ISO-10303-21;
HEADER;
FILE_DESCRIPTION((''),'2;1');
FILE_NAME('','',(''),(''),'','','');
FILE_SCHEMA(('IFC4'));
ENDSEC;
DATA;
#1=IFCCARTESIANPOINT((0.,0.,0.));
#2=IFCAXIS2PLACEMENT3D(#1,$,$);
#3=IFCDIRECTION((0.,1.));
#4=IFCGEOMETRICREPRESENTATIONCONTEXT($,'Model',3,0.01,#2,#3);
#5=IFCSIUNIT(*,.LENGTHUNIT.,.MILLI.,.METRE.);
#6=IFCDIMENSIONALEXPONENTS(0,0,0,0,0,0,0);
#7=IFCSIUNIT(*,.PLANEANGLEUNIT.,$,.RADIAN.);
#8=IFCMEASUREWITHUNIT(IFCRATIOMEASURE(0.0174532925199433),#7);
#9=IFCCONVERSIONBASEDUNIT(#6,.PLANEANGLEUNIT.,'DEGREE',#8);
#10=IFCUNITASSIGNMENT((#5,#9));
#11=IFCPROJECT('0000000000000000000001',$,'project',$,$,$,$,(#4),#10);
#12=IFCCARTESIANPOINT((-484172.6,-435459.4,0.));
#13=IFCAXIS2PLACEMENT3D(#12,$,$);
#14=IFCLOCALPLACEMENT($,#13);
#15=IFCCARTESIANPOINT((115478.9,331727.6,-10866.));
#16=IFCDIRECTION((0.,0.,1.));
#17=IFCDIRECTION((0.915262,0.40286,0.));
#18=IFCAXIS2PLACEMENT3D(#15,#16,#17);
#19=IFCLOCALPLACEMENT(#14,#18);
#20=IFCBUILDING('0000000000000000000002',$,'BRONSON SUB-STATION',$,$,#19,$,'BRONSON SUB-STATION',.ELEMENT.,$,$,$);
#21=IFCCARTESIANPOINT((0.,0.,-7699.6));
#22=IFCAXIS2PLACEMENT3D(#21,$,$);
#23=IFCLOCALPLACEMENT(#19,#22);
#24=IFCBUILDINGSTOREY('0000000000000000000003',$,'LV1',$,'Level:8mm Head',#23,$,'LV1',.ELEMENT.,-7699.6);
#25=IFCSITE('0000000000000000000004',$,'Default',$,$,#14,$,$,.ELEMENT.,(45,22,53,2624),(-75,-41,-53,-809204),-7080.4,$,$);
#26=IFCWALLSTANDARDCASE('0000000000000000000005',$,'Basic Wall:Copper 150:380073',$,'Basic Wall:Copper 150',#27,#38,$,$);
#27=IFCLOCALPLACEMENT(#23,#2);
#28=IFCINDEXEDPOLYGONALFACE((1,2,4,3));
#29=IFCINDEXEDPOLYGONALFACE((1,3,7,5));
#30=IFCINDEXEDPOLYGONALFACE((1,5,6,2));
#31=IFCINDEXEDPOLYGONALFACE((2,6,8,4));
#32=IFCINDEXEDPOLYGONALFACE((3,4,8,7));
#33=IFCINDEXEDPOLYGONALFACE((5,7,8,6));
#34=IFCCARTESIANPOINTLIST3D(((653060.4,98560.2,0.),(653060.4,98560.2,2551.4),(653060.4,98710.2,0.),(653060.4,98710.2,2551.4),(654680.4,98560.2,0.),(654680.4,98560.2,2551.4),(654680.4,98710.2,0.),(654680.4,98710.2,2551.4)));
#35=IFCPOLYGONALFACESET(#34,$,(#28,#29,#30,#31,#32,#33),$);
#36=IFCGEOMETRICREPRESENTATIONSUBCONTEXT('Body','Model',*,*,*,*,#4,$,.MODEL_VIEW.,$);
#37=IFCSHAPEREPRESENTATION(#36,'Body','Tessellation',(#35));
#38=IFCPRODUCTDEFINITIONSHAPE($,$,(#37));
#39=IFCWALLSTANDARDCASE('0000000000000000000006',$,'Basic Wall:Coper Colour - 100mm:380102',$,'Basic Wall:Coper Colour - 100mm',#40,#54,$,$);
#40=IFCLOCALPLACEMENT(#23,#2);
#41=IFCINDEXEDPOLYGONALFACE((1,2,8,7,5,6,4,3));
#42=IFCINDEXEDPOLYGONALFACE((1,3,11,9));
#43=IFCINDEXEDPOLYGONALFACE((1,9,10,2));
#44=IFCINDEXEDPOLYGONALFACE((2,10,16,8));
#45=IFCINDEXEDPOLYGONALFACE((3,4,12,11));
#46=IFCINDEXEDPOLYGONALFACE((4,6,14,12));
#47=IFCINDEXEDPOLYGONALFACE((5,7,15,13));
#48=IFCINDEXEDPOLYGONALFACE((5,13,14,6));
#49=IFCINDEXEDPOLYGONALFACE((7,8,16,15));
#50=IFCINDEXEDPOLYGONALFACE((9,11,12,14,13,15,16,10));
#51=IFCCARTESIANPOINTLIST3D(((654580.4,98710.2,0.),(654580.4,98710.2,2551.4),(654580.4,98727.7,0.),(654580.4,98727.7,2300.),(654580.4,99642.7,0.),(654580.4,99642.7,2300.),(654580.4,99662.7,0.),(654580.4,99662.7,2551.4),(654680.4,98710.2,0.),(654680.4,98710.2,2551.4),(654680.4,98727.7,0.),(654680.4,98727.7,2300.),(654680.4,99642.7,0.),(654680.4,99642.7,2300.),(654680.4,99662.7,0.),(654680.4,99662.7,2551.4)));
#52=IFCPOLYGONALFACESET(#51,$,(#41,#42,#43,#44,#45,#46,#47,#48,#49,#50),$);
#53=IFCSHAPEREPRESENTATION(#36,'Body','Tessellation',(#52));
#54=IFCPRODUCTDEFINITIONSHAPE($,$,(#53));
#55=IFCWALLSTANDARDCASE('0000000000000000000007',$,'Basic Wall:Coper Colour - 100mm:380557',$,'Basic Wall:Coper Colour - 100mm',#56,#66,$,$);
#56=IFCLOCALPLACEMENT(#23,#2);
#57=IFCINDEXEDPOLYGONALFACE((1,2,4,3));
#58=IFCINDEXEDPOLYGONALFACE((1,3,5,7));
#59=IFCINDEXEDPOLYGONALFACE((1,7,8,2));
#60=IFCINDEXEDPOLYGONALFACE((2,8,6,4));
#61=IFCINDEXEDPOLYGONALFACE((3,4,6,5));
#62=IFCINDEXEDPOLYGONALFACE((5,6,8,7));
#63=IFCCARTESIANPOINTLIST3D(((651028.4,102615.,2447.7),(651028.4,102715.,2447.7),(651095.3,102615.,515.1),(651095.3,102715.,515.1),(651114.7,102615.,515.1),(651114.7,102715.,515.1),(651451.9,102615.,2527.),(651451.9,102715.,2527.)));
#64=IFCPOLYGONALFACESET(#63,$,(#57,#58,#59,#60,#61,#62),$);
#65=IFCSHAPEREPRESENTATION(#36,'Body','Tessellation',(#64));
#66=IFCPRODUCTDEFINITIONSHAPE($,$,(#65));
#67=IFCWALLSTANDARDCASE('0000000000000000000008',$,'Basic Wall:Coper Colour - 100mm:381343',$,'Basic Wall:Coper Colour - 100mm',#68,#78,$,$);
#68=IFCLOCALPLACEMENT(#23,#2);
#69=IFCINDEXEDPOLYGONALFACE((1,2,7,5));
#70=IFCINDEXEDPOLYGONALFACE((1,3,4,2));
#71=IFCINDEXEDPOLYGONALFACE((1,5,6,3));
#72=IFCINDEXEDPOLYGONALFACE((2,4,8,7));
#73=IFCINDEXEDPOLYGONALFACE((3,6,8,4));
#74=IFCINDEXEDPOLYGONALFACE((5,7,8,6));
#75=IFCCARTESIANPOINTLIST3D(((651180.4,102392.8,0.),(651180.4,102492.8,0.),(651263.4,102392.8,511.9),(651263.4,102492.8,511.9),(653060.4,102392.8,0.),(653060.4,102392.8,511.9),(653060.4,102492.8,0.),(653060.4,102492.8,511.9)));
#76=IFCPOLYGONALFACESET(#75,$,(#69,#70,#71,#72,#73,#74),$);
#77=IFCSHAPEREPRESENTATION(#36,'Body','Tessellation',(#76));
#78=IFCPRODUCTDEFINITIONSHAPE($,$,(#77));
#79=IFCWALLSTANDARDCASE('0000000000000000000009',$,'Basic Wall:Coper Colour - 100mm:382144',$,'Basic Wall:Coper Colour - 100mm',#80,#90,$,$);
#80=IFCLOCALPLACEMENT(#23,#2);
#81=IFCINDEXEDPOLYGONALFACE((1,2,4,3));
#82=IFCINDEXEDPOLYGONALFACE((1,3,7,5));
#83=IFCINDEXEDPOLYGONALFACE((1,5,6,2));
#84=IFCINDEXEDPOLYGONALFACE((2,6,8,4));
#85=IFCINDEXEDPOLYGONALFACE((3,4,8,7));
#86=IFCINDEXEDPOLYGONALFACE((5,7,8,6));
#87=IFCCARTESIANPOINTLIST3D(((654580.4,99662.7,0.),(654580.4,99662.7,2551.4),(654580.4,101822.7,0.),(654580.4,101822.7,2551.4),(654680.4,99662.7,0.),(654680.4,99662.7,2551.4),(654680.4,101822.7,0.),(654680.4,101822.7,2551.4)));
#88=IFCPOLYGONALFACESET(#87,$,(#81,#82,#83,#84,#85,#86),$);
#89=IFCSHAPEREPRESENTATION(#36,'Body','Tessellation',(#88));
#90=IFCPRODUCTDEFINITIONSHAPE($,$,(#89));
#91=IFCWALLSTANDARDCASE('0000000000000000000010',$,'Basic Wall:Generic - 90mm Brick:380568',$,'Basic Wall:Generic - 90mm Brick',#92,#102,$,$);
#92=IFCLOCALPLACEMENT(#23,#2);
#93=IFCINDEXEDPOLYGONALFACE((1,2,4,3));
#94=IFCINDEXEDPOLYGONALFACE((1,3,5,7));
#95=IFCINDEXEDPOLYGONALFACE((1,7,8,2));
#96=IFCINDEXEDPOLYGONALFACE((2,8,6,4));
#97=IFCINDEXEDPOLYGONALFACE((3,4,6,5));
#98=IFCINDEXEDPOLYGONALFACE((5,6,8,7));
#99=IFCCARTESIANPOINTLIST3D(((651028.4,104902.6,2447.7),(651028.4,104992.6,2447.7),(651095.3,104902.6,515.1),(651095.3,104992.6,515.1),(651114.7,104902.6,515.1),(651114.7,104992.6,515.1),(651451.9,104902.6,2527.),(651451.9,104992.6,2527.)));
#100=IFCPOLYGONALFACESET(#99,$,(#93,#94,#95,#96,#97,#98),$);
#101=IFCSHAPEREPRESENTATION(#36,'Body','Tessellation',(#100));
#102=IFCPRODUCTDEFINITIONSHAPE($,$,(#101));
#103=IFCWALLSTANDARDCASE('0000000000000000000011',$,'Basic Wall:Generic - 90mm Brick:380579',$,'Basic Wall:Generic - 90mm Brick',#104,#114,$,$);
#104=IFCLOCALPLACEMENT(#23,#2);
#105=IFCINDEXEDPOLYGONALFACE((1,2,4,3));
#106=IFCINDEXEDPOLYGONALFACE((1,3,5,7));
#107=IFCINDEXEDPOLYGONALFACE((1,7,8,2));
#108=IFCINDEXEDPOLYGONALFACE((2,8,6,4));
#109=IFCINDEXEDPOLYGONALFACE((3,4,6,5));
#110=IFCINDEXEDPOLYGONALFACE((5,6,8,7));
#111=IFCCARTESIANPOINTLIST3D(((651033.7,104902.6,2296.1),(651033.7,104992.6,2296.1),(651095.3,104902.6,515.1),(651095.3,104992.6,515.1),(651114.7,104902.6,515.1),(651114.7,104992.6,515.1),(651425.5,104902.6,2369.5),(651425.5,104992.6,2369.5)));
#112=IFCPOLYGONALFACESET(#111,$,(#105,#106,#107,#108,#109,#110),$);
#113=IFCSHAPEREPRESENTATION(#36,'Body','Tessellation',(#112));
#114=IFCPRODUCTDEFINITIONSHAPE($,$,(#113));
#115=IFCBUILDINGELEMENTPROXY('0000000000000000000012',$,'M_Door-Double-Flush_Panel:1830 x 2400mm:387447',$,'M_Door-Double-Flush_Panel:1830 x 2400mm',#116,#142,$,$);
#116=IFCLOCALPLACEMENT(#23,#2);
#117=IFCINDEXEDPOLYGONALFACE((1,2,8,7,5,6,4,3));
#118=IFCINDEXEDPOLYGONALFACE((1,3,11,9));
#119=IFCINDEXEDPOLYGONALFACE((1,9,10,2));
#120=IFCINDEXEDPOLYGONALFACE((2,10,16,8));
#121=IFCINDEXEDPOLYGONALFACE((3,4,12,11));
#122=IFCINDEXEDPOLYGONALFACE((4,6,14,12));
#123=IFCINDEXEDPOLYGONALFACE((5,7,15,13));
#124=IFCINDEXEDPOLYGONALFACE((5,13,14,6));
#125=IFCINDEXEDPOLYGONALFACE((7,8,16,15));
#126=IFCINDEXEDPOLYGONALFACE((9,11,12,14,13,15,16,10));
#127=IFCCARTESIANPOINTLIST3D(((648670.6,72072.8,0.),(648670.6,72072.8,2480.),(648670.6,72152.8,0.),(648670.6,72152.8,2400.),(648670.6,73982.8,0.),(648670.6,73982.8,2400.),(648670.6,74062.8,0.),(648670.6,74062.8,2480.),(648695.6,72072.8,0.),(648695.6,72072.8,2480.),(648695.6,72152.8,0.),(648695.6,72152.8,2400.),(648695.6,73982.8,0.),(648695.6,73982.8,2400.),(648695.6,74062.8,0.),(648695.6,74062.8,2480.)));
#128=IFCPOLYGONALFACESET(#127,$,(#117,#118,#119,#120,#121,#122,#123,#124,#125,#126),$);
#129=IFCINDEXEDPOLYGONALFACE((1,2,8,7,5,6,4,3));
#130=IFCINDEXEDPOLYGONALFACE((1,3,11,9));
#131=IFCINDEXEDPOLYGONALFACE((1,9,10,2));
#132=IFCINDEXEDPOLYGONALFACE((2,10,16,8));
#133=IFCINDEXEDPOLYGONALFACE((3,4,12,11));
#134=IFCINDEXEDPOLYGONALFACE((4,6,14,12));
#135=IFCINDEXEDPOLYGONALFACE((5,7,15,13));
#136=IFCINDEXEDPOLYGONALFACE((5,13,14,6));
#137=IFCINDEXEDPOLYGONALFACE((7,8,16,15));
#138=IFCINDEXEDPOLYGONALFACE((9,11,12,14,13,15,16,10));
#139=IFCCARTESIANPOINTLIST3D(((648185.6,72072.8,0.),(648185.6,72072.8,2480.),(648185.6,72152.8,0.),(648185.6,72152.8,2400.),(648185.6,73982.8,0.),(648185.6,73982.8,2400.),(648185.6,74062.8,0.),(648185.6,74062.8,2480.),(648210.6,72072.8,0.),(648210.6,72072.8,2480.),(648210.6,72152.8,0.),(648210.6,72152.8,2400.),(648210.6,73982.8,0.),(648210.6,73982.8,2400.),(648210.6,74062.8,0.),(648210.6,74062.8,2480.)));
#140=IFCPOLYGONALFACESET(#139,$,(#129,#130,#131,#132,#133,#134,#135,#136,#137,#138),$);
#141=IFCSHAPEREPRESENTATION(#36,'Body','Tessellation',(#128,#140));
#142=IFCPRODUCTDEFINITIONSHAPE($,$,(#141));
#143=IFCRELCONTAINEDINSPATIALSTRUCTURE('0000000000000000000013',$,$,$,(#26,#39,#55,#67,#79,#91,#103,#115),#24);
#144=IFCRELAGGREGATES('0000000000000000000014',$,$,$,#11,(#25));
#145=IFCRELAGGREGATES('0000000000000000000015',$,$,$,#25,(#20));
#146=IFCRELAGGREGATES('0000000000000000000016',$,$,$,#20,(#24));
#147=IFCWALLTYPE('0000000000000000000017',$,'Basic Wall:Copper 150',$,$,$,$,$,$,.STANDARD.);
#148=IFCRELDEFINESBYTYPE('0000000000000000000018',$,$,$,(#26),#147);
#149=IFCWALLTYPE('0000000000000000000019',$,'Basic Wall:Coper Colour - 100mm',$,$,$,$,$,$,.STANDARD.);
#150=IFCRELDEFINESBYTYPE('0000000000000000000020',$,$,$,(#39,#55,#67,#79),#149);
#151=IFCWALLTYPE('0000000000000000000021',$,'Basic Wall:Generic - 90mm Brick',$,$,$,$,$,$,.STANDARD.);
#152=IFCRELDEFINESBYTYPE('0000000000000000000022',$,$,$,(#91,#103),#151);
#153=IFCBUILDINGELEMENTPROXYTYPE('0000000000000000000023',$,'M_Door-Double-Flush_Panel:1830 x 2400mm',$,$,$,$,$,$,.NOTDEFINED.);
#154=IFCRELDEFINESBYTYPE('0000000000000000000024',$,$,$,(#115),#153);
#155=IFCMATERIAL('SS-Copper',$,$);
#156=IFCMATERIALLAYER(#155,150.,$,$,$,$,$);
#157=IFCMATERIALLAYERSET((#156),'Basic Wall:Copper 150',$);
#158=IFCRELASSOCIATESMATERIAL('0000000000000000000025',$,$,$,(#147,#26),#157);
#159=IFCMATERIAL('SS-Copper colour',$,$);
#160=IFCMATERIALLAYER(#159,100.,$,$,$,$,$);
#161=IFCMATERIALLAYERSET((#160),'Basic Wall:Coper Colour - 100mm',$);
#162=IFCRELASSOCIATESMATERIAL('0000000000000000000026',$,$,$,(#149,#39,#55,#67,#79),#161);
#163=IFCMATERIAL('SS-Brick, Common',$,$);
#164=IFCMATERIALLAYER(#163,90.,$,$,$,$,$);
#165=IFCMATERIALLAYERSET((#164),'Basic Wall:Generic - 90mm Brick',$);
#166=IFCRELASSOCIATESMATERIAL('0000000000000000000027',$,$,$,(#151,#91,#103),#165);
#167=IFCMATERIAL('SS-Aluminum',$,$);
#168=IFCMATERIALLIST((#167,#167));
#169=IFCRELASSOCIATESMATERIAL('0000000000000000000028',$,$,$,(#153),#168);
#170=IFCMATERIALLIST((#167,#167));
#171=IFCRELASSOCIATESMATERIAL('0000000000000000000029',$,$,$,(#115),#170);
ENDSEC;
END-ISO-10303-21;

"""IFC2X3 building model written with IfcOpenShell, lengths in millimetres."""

from ifc_helpers import new_model, entity, si_unit, converted_unit, direction, frame, frame_2d, origin, place, context, subcontext, project, spatial, polyline, rectangle, outline, extrude, clip, halfspace, source, transform, mapped, material, material_list, layer, layer_set, layer_usage, type_object, type_shapes, element, save


model = new_model("IFC2X3")

# Units and contexts
model_context = context("Model", 3, precision=0.01, world=origin(), true_north=direction((0.0, 1.0)))
body_context = subcontext(model_context, "Body", "Model", "MODEL_VIEW")
ifc_project = project(units=[si_unit("LENGTHUNIT", "METRE", prefix="MILLI"), converted_unit("PLANEANGLEUNIT", "DEGREE", entity("IfcRatioMeasure", 0.0174532925199433), si_unit("PLANEANGLEUNIT", "RADIAN"), dimensions=[0, 0, 0, 0, 0, 0, 0])], contexts=[model_context])

# Site, building, storey
site_placement = place(None, frame((-484172.6, -435459.4, 0.0)))
site = spatial("IfcSite", under=ifc_project, at=site_placement, Name="Default", CompositionType="ELEMENT", RefLatitude=(45, 22, 53, 2624), RefLongitude=(-75, -41, -53, -809204), RefElevation=-7080.4)
building_placement = place(site_placement, frame((115478.9, 331727.6, -10866.0), z_axis=(0.0, 0.0, 1.0), x_axis=(0.915262, 0.40286, 0.0)))
building = spatial("IfcBuilding", under=site, at=building_placement, Name="BRONSON SUB-STATION", LongName="BRONSON SUB-STATION", CompositionType="ELEMENT")
storey_placement = place(building_placement, frame((0.0, 0.0, -7699.6)))
storey = spatial("IfcBuildingStorey", under=building, at=storey_placement, Name="LV1", ObjectType="Level:8mm Head", LongName="LV1", CompositionType="ELEMENT", Elevation=-7699.6)

# Shared definitions
ifc_material_1 = material(Name="SS-Copper")
ifc_layer_1 = layer(ifc_material_1, 150.0)
ifc_layer_set_1 = layer_set([ifc_layer_1], Name="Basic Wall:Copper 150")
wall_type_1 = type_object("IfcWallType", Name="Basic Wall:Copper 150", PredefinedType="STANDARD", material=ifc_layer_set_1)

# Wall
ifc_layer_usage_1 = layer_usage(ifc_layer_set_1, "AXIS2", "NEGATIVE", 75.0)
wall_1_placement = place(storey_placement, frame((653060.4, 98635.2, 0.0)))
element("IfcWallStandardCase", 1, at=wall_1_placement, inside=storey, type_object=wall_type_1, material=ifc_layer_usage_1, Name="Basic Wall:Copper 150:380073", ObjectType="Basic Wall:Copper 150", context=body_context, shape_type="SweptSolid", body=[
    extrude(rectangle(XDim=1620.0, YDim=150.0, at=frame_2d((810.0, 0.0), x_axis=(-1.0, 0.0))), origin(), (0.0, 0.0, 1.0), 2551.4),
])

# Wall, opening
ifc_material_2 = material(Name="SS-Copper colour")
ifc_layer_2 = layer(ifc_material_2, 100.0)
ifc_layer_set_2 = layer_set([ifc_layer_2], Name="Basic Wall:Coper Colour - 100mm")
ifc_layer_usage_2 = layer_usage(ifc_layer_set_2, "AXIS2", "NEGATIVE", 50.0)
wall_type_2 = type_object("IfcWallType", Name="Basic Wall:Coper Colour - 100mm", PredefinedType="STANDARD", material=ifc_layer_set_2)
wall_2_placement = place(storey_placement, frame((654630.4, 98710.2, 0.0), z_axis=(0.0, 0.0, 1.0), x_axis=(0.0, 1.0, 0.0)))
wall_2 = element("IfcWallStandardCase", 2, at=wall_2_placement, inside=storey, type_object=wall_type_2, material=ifc_layer_usage_2, Name="Basic Wall:Coper Colour - 100mm:380102", ObjectType="Basic Wall:Coper Colour - 100mm", context=body_context, shape_type="SweptSolid", body=[
    extrude(rectangle(XDim=952.5, YDim=100.0, at=frame_2d((476.3, 0.0), x_axis=(-1.0, 0.0))), origin(), (0.0, 0.0, 1.0), 2551.4),
])
opening_1_placement = place(wall_2_placement, origin())
element("IfcOpeningElement", 3, at=opening_1_placement, cuts=wall_2, ObjectType="Opening", context=body_context, shape_type="SweptSolid", body=[
    extrude(rectangle(XDim=2300.0, YDim=915.0, at=frame_2d((0.0, 0.0), x_axis=(1.0, 0.0))), frame((475.0, -1574.0, 1150.0), z_axis=(0.0, 1.0, 0.0), x_axis=(0.0, 0.0, 1.0)), (0.0, 0.0, 1.0), 3048.0),
])

# Walls
ifc_layer_usage_3 = layer_usage(ifc_layer_set_2, "AXIS2", "POSITIVE", -50.0)
wall_3_placement = place(storey_placement, frame((651028.4, 102665.0, 515.1)))
element("IfcWallStandardCase", 4, at=wall_3_placement, inside=storey, type_object=wall_type_2, material=ifc_layer_usage_3, Name="Basic Wall:Coper Colour - 100mm:380557", ObjectType="Basic Wall:Coper Colour - 100mm", context=body_context, shape_type="Clipping", body=[
    clip(clip(clip(clip(extrude(rectangle(XDim=423.5, YDim=100.0, at=frame_2d((211.8, 0.0), x_axis=(-1.0, 0.0))), origin(), (0.0, 0.0, 1.0), 2011.9), halfspace(frame((66.9, -50.0, 0.0), z_axis=(-0.999401, 0.0, -0.034613), x_axis=(0.0, 1.0, 0.0)), False)), halfspace(frame((86.3, -50.0, 0.0), z_axis=(0.0, 0.0, -1.0), x_axis=(0.0, 1.0, 0.0)), False)), halfspace(frame((423.5, -50.0, 2011.9), z_axis=(0.986245, 0.0, -0.165292), x_axis=(0.0, 1.0, 0.0)), False)), halfspace(frame((0.0, -50.0, 1932.6), z_axis=(-0.184096, 0.0, 0.982908), x_axis=(0.0, 1.0, 0.0)), False)),
])
ifc_layer_usage_4 = layer_usage(ifc_layer_set_2, "AXIS2", "POSITIVE", -50.0)
wall_4_placement = place(storey_placement, frame((651180.4, 102442.8, 0.0)))
element("IfcWallStandardCase", 5, at=wall_4_placement, inside=storey, type_object=wall_type_2, material=ifc_layer_usage_4, Name="Basic Wall:Coper Colour - 100mm:381343", ObjectType="Basic Wall:Coper Colour - 100mm", context=body_context, shape_type="Clipping", body=[
    clip(extrude(rectangle(XDim=1880.0, YDim=100.0, at=frame_2d((940.0, 0.0), x_axis=(-1.0, 0.0))), origin(), (0.0, 0.0, 1.0), 511.9), halfspace(frame((0.0, -50.0, 0.0), z_axis=(-0.987105, 0.0, 0.160071), x_axis=(0.0, 1.0, 0.0)), False)),
])
ifc_layer_usage_5 = layer_usage(ifc_layer_set_2, "AXIS2", "NEGATIVE", 50.0)
wall_5_placement = place(storey_placement, frame((654630.4, 99662.7, 0.0), z_axis=(0.0, 0.0, 1.0), x_axis=(0.0, 1.0, 0.0)))
element("IfcWallStandardCase", 6, at=wall_5_placement, inside=storey, type_object=wall_type_2, material=ifc_layer_usage_5, Name="Basic Wall:Coper Colour - 100mm:382144", ObjectType="Basic Wall:Coper Colour - 100mm", context=body_context, shape_type="SweptSolid", body=[
    extrude(rectangle(XDim=2159.9, YDim=100.0, at=frame_2d((1080.0, 0.0), x_axis=(-1.0, 0.0))), origin(), (0.0, 0.0, 1.0), 2551.4),
])
ifc_material_3 = material(Name="SS-Brick, Common")
ifc_layer_3 = layer(ifc_material_3, 90.0)
ifc_layer_set_3 = layer_set([ifc_layer_3], Name="Basic Wall:Generic - 90mm Brick")
ifc_layer_usage_6 = layer_usage(ifc_layer_set_3, "AXIS2", "POSITIVE", -45.0)
wall_type_3 = type_object("IfcWallType", Name="Basic Wall:Generic - 90mm Brick", PredefinedType="STANDARD", material=ifc_layer_set_3)
wall_6_placement = place(storey_placement, frame((651451.9, 104947.6, 515.1), z_axis=(0.0, 0.0, 1.0), x_axis=(-1.0, 0.0, 0.0)))
element("IfcWallStandardCase", 7, at=wall_6_placement, inside=storey, type_object=wall_type_3, material=ifc_layer_usage_6, Name="Basic Wall:Generic - 90mm Brick:380568", ObjectType="Basic Wall:Generic - 90mm Brick", context=body_context, shape_type="Clipping", body=[
    clip(clip(clip(clip(extrude(rectangle(XDim=423.5, YDim=90.0, at=frame_2d((211.8, 0.0), x_axis=(-1.0, 0.0))), origin(), (0.0, 0.0, 1.0), 2011.9), halfspace(frame((423.5, -45.0, 1932.6), z_axis=(0.999401, 0.0, -0.034613), x_axis=(0.0, 1.0, 0.0)), False)), halfspace(frame((0.0, -45.0, 2011.9), z_axis=(0.184096, 0.0, 0.982908), x_axis=(0.0, 1.0, 0.0)), False)), halfspace(frame((337.2, -45.0, 0.0), z_axis=(-0.986245, 0.0, -0.165292), x_axis=(0.0, 1.0, 0.0)), False)), halfspace(frame((356.6, -45.0, 0.0), z_axis=(0.0, 0.0, -1.0), x_axis=(0.0, 1.0, 0.0)), False)),
])
ifc_layer_usage_7 = layer_usage(ifc_layer_set_3, "AXIS2", "POSITIVE", -45.0)
wall_7_placement = place(storey_placement, frame((651425.5, 104947.6, 515.1), z_axis=(0.0, 0.0, 1.0), x_axis=(-1.0, 0.0, 0.0)))
element("IfcWallStandardCase", 8, at=wall_7_placement, inside=storey, type_object=wall_type_3, material=ifc_layer_usage_7, Name="Basic Wall:Generic - 90mm Brick:380579", ObjectType="Basic Wall:Generic - 90mm Brick", context=body_context, shape_type="Clipping", body=[
    clip(clip(clip(clip(extrude(rectangle(XDim=391.9, YDim=90.0, at=frame_2d((195.9, 0.0), x_axis=(-1.0, 0.0))), origin(), (0.0, 0.0, 1.0), 1854.4), halfspace(frame((391.9, -45.0, 1781.0), z_axis=(0.999401, 0.0, -0.034613), x_axis=(0.0, 1.0, 0.0)), False)), halfspace(frame((0.0, -45.0, 1854.4), z_axis=(0.184096, 0.0, 0.982908), x_axis=(0.0, 1.0, 0.0)), False)), halfspace(frame((310.8, -45.0, 0.0), z_axis=(-0.986245, 0.0, -0.165292), x_axis=(0.0, 1.0, 0.0)), False)), halfspace(frame((330.2, -45.0, 0.0), z_axis=(0.0, 0.0, -1.0), x_axis=(0.0, 1.0, 0.0)), False)),
])

# Building element proxy
ifc_material_4 = material(Name="SS-Aluminum")
ifc_material_list_1 = material_list([ifc_material_4, ifc_material_4])
ifc_material_list_2 = material_list([ifc_material_4, ifc_material_4])
building_element_proxy_type_1 = type_object("IfcBuildingElementProxyType", Name="M_Door-Double-Flush_Panel:1830 x 2400mm", PredefinedType="NOTDEFINED", material=ifc_material_list_2)
shared_shape_1 = source(origin(), body_context, "Body", "SweptSolid", [
    extrude(outline(polyline([(-1180.0, 915.0), (1220.0, 915.0), (1220.0, 995.0), (-1260.0, 995.0), (-1260.0, -995.0), (1220.0, -995.0), (1220.0, -915.0), (-1180.0, -915.0), (-1180.0, 915.0)])), frame((0.0, 230.0, 1220.0), z_axis=(0.0, 1.0, 0.0), x_axis=(0.0, 0.0, -1.0)), (0.0, 0.0, 1.0), 25.0),
    extrude(outline(polyline([(-1180.0, 915.0), (1220.0, 915.0), (1220.0, 995.0), (-1260.0, 995.0), (-1260.0, -995.0), (1220.0, -995.0), (1220.0, -915.0), (-1180.0, -915.0), (-1180.0, 915.0)])), frame((0.0, -255.0, 1220.0), z_axis=(0.0, 1.0, 0.0), x_axis=(0.0, 0.0, -1.0)), (0.0, 0.0, 1.0), 25.0),
])
type_shapes(building_element_proxy_type_1, [shared_shape_1])
proxy_1_placement = place(storey_placement, frame((648440.6, 73067.8, 0.0), z_axis=(0.0, 0.0, 1.0), x_axis=(0.0, -1.0, 0.0)))
element("IfcBuildingElementProxy", 9, at=proxy_1_placement, inside=storey, type_object=building_element_proxy_type_1, material=ifc_material_list_1, Name="M_Door-Double-Flush_Panel:1830 x 2400mm:387447", ObjectType="M_Door-Double-Flush_Panel:1830 x 2400mm", context=body_context, shape_type="MappedRepresentation", body=[
    mapped(shared_shape_1, transform((0.0, 0.0, 0.0), scale=1.0)),
])

save(model, "model.ifc")
